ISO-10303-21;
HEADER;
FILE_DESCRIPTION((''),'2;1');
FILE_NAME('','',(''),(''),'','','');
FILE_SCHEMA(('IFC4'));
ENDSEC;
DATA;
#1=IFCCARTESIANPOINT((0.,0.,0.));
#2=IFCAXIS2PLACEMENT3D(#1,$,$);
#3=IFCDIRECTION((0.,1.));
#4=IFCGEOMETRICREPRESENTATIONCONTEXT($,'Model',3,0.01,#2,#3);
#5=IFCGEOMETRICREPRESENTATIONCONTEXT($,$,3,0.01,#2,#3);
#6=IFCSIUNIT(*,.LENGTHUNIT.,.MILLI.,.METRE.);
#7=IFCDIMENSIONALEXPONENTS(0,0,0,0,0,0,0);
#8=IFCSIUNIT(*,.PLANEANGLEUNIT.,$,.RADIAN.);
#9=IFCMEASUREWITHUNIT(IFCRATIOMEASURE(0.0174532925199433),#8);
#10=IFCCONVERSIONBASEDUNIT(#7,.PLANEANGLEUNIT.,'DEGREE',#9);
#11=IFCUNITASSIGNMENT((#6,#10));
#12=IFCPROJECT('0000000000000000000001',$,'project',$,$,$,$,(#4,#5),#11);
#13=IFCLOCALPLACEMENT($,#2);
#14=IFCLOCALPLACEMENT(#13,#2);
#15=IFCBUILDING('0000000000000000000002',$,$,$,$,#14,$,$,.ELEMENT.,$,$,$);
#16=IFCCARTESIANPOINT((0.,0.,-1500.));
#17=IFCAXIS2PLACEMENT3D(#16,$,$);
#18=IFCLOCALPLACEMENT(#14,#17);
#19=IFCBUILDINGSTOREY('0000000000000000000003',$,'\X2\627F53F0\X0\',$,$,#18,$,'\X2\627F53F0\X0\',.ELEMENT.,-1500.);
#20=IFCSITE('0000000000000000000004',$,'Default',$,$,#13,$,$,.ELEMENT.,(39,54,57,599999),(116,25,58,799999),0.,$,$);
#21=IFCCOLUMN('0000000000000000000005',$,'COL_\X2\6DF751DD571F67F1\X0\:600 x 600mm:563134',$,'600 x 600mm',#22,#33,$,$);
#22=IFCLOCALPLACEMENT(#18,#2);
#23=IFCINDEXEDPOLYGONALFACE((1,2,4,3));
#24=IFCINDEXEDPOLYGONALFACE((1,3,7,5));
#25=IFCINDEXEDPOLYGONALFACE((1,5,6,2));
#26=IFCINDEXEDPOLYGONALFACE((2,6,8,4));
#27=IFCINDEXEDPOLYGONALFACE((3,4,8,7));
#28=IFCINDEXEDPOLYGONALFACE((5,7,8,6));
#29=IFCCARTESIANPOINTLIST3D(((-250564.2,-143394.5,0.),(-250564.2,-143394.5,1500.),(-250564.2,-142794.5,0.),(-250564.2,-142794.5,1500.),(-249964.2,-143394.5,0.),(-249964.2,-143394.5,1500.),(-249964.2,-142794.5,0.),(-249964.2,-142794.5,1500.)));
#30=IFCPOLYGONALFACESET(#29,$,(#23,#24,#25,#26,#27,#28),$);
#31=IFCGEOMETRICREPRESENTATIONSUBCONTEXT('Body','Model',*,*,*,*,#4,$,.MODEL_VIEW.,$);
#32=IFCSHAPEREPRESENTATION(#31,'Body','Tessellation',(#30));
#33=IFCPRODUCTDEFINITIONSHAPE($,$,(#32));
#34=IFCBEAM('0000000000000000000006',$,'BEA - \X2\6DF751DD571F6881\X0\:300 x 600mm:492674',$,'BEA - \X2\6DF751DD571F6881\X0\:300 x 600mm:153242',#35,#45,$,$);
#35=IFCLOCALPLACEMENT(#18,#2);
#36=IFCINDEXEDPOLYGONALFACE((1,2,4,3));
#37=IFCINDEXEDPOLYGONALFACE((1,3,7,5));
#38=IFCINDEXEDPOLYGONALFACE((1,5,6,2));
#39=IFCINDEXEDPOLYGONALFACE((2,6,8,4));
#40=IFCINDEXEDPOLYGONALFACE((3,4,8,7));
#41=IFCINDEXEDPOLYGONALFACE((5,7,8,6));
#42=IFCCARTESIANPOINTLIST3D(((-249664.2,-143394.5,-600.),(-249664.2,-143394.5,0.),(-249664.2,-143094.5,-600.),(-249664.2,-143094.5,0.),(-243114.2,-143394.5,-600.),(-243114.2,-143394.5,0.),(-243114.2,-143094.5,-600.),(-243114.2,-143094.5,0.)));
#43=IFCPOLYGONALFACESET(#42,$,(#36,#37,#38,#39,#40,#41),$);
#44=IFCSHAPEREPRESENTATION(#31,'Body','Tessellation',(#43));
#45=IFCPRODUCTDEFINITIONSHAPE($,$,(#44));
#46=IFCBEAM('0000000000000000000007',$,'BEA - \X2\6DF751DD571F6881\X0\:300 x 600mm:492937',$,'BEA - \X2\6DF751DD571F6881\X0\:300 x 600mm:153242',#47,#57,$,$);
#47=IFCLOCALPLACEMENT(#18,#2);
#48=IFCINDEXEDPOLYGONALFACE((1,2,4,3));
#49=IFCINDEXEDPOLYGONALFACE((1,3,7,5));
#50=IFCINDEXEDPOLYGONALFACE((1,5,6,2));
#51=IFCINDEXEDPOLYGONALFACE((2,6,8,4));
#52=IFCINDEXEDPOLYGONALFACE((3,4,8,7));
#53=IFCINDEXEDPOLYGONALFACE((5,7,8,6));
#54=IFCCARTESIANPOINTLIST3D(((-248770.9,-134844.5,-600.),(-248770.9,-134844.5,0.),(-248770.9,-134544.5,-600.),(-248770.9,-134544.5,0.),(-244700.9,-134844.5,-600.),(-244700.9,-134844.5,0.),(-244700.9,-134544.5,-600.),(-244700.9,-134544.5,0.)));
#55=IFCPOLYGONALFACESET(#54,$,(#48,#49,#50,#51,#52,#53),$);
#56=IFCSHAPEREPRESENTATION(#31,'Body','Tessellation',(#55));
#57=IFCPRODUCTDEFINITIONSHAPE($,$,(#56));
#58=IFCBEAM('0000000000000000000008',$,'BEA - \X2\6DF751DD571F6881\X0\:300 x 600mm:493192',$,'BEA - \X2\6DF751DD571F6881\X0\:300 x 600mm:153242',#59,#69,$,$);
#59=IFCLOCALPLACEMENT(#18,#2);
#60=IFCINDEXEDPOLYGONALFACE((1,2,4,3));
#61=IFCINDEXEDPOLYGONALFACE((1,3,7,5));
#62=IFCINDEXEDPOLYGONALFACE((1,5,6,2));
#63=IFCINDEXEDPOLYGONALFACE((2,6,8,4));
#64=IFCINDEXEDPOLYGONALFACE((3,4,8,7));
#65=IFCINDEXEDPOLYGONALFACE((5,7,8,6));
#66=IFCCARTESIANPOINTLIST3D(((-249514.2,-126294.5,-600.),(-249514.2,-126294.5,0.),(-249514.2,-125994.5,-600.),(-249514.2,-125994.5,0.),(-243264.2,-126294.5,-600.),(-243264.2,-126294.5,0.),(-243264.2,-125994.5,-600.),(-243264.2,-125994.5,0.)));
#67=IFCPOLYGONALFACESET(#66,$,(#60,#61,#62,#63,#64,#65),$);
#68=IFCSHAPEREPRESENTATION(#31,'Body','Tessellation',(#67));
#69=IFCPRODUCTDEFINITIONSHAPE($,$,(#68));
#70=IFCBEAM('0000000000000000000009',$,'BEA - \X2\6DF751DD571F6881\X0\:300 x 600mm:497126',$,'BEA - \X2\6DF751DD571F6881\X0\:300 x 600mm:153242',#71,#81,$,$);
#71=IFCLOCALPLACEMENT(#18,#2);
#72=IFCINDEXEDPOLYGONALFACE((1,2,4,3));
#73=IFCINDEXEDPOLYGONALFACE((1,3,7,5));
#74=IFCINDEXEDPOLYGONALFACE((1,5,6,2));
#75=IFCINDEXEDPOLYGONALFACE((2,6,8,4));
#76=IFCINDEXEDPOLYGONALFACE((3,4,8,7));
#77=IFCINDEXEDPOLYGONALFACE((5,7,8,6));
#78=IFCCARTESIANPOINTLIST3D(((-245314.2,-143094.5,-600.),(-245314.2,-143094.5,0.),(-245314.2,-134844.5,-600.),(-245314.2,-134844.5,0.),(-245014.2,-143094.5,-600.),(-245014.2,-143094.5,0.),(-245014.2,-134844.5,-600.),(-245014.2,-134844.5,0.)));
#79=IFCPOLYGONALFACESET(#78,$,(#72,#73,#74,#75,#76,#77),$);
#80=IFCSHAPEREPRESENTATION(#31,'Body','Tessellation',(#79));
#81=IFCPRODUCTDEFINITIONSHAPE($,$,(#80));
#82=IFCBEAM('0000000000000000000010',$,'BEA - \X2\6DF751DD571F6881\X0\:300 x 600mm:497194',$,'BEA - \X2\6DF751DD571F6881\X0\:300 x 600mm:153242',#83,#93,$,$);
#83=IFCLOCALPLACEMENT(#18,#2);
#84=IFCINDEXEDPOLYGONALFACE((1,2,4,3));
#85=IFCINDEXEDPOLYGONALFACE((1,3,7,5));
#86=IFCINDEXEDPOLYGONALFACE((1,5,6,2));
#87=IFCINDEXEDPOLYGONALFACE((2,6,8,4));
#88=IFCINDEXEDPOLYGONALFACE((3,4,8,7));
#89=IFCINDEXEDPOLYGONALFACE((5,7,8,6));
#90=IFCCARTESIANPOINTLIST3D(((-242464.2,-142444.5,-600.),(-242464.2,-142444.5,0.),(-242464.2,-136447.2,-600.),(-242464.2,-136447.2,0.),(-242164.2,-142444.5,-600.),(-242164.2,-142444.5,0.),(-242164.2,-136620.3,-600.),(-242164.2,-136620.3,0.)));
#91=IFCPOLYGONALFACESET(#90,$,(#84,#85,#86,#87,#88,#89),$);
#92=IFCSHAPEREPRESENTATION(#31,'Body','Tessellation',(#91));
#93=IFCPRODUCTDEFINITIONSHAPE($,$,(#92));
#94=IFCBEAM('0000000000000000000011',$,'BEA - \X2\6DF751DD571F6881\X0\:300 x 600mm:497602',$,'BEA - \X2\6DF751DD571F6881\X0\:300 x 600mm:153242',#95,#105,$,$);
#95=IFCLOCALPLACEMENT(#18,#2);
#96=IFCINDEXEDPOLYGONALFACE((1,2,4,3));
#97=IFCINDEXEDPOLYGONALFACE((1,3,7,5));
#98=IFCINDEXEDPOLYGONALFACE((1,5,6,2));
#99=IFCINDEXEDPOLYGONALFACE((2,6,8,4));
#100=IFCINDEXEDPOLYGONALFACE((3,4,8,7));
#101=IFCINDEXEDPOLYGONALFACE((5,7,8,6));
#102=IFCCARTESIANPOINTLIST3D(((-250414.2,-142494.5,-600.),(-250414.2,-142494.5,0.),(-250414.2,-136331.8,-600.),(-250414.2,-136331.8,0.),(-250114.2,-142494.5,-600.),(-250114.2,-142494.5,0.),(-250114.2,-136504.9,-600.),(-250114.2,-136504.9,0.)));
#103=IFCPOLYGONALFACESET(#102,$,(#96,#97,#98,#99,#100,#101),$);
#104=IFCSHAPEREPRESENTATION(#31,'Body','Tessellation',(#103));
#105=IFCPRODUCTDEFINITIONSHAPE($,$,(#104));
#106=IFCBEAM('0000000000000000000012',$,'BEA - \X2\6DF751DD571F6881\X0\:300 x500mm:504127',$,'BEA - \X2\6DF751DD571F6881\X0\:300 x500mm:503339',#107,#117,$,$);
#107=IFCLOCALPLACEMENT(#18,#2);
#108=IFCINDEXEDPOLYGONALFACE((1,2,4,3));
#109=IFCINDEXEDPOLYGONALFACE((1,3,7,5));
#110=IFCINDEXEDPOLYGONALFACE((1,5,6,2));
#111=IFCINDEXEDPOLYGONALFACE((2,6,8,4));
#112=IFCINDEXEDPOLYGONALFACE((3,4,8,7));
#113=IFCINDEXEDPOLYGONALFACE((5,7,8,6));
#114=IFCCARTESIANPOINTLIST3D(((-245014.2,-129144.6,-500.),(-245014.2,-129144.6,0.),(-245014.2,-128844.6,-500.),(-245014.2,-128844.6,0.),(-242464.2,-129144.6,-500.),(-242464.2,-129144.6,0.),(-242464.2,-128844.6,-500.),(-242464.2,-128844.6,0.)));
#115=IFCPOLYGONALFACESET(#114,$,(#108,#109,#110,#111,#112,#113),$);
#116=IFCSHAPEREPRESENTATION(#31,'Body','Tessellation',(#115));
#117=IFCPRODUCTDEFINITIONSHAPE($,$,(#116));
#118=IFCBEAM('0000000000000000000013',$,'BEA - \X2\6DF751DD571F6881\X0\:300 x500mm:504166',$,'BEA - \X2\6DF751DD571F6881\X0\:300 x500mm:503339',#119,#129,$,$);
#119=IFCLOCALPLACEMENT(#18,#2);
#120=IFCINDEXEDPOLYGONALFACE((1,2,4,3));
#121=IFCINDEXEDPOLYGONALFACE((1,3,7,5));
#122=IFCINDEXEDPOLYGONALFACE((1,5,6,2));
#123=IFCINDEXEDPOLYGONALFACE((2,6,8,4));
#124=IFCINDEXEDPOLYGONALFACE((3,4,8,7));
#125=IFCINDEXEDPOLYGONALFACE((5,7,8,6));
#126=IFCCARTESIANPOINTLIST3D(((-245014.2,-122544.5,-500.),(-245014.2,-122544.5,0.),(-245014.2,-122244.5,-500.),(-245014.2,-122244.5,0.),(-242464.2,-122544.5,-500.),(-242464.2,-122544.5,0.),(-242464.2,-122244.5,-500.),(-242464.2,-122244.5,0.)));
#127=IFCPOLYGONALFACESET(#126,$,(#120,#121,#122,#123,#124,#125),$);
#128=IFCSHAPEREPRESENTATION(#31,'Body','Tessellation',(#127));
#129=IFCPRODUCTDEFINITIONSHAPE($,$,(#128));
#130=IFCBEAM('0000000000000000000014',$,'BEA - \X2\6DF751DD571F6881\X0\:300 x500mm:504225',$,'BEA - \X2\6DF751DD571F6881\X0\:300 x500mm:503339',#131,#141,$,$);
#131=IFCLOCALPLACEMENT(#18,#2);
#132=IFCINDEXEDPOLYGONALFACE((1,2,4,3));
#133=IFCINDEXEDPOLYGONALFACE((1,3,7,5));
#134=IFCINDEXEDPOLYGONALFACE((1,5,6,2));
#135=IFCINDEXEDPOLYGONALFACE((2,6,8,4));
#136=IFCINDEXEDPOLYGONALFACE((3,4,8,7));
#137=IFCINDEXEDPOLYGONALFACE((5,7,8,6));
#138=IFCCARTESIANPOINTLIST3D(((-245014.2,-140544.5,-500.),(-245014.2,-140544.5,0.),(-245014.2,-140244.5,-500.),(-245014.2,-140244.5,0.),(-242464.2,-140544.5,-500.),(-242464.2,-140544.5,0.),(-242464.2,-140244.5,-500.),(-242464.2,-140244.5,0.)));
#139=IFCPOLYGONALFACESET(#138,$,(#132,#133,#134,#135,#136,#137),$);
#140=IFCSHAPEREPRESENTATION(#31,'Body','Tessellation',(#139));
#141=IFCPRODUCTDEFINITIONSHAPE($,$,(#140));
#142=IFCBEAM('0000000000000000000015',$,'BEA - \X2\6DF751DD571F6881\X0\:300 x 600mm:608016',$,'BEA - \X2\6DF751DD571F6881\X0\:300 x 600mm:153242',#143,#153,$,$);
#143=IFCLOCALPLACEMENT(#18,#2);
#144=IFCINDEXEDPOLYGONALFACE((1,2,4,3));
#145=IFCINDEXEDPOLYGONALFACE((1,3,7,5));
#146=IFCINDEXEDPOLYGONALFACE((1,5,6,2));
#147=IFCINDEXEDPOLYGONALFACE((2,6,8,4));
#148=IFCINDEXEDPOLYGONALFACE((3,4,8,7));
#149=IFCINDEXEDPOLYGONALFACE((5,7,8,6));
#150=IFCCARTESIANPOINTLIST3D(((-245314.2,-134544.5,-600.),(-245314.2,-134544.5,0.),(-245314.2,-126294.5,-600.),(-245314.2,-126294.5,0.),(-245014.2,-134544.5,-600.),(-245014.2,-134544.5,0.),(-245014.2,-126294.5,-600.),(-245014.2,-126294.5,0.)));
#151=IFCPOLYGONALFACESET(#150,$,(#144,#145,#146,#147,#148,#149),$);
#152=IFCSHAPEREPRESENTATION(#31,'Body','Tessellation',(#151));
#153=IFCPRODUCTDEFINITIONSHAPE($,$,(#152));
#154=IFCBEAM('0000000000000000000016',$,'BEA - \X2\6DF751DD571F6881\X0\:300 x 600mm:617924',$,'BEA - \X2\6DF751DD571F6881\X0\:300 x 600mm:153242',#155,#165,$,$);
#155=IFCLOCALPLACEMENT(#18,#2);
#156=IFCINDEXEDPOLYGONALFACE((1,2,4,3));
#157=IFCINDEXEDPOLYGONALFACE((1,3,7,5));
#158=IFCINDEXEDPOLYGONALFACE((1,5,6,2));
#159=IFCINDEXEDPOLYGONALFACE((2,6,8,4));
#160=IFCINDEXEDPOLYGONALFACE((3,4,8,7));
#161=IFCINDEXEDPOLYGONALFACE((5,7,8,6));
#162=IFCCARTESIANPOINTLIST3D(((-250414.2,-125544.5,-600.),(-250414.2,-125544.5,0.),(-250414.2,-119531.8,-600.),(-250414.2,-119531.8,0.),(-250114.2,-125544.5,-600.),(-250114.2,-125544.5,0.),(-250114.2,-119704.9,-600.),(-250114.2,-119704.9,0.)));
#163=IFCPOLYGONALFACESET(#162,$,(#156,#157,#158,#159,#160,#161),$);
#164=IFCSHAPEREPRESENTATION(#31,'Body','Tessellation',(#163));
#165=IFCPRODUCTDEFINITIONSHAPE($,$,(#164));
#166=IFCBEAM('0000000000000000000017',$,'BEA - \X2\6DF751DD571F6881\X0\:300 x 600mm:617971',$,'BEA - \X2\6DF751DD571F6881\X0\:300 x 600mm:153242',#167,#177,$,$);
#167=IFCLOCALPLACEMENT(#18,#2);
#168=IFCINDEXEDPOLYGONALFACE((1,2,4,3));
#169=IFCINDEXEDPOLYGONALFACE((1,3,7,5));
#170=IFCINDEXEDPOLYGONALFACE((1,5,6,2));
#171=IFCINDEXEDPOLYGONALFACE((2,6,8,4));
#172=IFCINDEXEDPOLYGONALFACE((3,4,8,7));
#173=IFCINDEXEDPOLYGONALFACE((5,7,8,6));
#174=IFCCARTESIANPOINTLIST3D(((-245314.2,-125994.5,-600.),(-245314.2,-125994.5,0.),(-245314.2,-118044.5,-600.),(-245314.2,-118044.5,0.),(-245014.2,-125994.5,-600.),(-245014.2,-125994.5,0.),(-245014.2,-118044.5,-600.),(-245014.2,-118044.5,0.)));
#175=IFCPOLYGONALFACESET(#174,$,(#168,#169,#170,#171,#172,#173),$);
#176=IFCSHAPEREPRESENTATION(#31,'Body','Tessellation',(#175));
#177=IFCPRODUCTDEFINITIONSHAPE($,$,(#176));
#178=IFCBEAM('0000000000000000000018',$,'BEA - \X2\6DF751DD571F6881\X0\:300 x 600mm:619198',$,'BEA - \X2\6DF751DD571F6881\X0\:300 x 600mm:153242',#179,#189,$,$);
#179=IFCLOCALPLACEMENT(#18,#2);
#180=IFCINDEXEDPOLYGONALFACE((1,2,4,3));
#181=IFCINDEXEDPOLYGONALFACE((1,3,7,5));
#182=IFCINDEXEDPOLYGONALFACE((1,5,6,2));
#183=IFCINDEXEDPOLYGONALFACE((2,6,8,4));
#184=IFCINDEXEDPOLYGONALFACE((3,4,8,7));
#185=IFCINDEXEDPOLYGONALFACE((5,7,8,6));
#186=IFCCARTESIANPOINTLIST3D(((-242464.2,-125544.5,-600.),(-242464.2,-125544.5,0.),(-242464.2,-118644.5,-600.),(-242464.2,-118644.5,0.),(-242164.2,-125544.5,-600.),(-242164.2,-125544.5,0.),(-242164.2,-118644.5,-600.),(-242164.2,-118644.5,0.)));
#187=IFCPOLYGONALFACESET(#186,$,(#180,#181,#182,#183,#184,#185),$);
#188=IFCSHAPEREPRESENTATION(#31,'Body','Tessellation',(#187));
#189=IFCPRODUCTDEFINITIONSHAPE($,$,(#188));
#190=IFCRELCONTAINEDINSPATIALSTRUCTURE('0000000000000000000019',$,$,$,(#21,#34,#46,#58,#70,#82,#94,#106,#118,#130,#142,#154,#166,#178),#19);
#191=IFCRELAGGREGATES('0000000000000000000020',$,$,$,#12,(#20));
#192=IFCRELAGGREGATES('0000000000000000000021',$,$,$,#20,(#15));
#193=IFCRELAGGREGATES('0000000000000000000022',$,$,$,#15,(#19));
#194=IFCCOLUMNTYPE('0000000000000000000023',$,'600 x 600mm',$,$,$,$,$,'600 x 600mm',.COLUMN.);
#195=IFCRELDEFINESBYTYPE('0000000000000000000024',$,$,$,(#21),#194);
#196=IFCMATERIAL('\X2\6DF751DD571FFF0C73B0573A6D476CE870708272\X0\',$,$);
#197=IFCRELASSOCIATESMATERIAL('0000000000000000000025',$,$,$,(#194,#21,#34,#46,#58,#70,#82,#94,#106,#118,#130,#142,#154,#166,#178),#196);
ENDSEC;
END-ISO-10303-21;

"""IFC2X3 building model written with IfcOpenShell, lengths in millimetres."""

from ifc_helpers import new_model, entity, si_unit, converted_unit, direction, frame, frame_2d, origin, origin_2d_with_axis, place, context, subcontext, project, spatial, rectangle, extrude, clip, halfspace, source, transform, mapped, material, type_object, type_shapes, element, save


model = new_model("IFC2X3")

# Units and contexts
model_context = context("Model", 3, precision=0.01, world=origin(), true_north=direction((0.0, 1.0)))
context_of_model = context(None, 3, precision=0.01, world=origin(), true_north=direction((0.0, 1.0)))
body_context = subcontext(model_context, "Body", "Model", "MODEL_VIEW")
ifc_project = project(units=[si_unit("LENGTHUNIT", "METRE", prefix="MILLI"), converted_unit("PLANEANGLEUNIT", "DEGREE", entity("IfcRatioMeasure", 0.0174532925199433), si_unit("PLANEANGLEUNIT", "RADIAN"), dimensions=[0, 0, 0, 0, 0, 0, 0])], contexts=[model_context, context_of_model])

# Site, building, storey
site_placement = place(None, origin())
site = spatial("IfcSite", under=ifc_project, at=site_placement, Name="Default", CompositionType="ELEMENT", RefLatitude=(39, 54, 57, 599999), RefLongitude=(116, 25, 58, 799999), RefElevation=0.0)
building_placement = place(site_placement, origin())
building = spatial("IfcBuilding", under=site, at=building_placement, CompositionType="ELEMENT")
storey_placement = place(building_placement, frame((0.0, 0.0, -1500.0)))
storey = spatial("IfcBuildingStorey", under=building, at=storey_placement, Name="承台", LongName="承台", CompositionType="ELEMENT", Elevation=-1500.0)

# Column
ifc_material_1 = material(Name="混凝土，现场浇注灰色")
column_type_1 = type_object("IfcColumnType", Name="600 x 600mm", ElementType="600 x 600mm", PredefinedType="COLUMN", material=ifc_material_1)
shared_shape_1 = source(origin(), body_context, "Body", "SweptSolid", [
    extrude(rectangle(XDim=600.0, YDim=600.0, at=origin_2d_with_axis()), frame((0.0, 0.0, -1500.0), z_axis=(0.0, 0.0, 1.0), x_axis=(-1.0, 0.0, 0.0)), (0.0, 0.0, 1.0), 1500.0),
])
type_shapes(column_type_1, [shared_shape_1])
for number, where, name in (
    (1, (-250264.2, -143094.5, 1500.0), "COL_混凝土柱:600 x 600mm:563134"),
):
    element("IfcColumn", number, at=place(storey_placement, frame(where)), inside=storey, type_object=column_type_1, material=ifc_material_1, Name=name, ObjectType="600 x 600mm", context=body_context, shape_type="MappedRepresentation", body=[
        mapped(shared_shape_1, transform((0.0, 0.0, 0.0), scale=1.0)),
    ])

# Beams
beam_1_placement = place(storey_placement, frame((-243114.2, -143244.5, 0.0), z_axis=(0.0, 0.0, 1.0), x_axis=(-1.0, 0.0, 0.0)))
element("IfcBeam", 2, at=beam_1_placement, inside=storey, material=ifc_material_1, Name="BEA - 混凝土梁:300 x 600mm:492674", ObjectType="BEA - 混凝土梁:300 x 600mm:153242", context=body_context, shape_type="SweptSolid", body=[
    extrude(rectangle(XDim=600.0, YDim=300.0, at=frame_2d((0.0, 0.0), x_axis=(1.0, 0.0))), frame((0.0, 0.0, -300.0), z_axis=(1.0, 0.0, 0.0), x_axis=(0.0, 0.0, -1.0)), (0.0, 0.0, 1.0), 6550.0),
])
beam_2_placement = place(storey_placement, frame((-244700.9, -134694.5, 0.0), z_axis=(0.0, 0.0, 1.0), x_axis=(-1.0, 0.0, 0.0)))
element("IfcBeam", 3, at=beam_2_placement, inside=storey, material=ifc_material_1, Name="BEA - 混凝土梁:300 x 600mm:492937", ObjectType="BEA - 混凝土梁:300 x 600mm:153242", context=body_context, shape_type="SweptSolid", body=[
    extrude(rectangle(XDim=600.0, YDim=300.0, at=frame_2d((0.0, 0.0), x_axis=(1.0, 0.0))), frame((0.0, 0.0, -300.0), z_axis=(1.0, 0.0, 0.0), x_axis=(0.0, 0.0, -1.0)), (0.0, 0.0, 1.0), 4070.0),
])
beam_3_placement = place(storey_placement, frame((-243264.2, -126144.5, 0.0), z_axis=(0.0, 0.0, 1.0), x_axis=(-1.0, 0.0, 0.0)))
element("IfcBeam", 4, at=beam_3_placement, inside=storey, material=ifc_material_1, Name="BEA - 混凝土梁:300 x 600mm:493192", ObjectType="BEA - 混凝土梁:300 x 600mm:153242", context=body_context, shape_type="SweptSolid", body=[
    extrude(rectangle(XDim=600.0, YDim=300.0, at=frame_2d((0.0, 0.0), x_axis=(1.0, 0.0))), frame((0.0, 0.0, -300.0), z_axis=(1.0, 0.0, 0.0), x_axis=(0.0, 0.0, -1.0)), (0.0, 0.0, 1.0), 6250.0),
])
beam_4_placement = place(storey_placement, frame((-245164.2, -143094.5, 0.0), z_axis=(0.0, 0.0, 1.0), x_axis=(0.0, 1.0, 0.0)))
element("IfcBeam", 5, at=beam_4_placement, inside=storey, material=ifc_material_1, Name="BEA - 混凝土梁:300 x 600mm:497126", ObjectType="BEA - 混凝土梁:300 x 600mm:153242", context=body_context, shape_type="SweptSolid", body=[
    extrude(rectangle(XDim=600.0, YDim=300.0, at=origin_2d_with_axis()), frame((0.0, 0.0, -300.0), z_axis=(1.0, 0.0, 0.0), x_axis=(0.0, 0.0, -1.0)), (0.0, 0.0, 1.0), 8250.0),
])
beam_5_placement = place(storey_placement, frame((-242314.2, -142444.5, 0.0), z_axis=(0.0, 0.0, 1.0), x_axis=(0.0, 1.0, 0.0)))
element("IfcBeam", 6, at=beam_5_placement, inside=storey, material=ifc_material_1, Name="BEA - 混凝土梁:300 x 600mm:497194", ObjectType="BEA - 混凝土梁:300 x 600mm:153242", context=body_context, shape_type="Clipping", body=[
    clip(extrude(rectangle(XDim=600.0, YDim=300.0, at=frame_2d((0.0, 0.0), x_axis=(1.0, 0.0))), frame((0.0, 0.0, -300.0), z_axis=(1.0, 0.0, 0.0), x_axis=(0.0, 0.0, -1.0)), (0.0, 0.0, 1.0), 5997.3), halfspace(frame((7288.0, 2386.7, 0.0), z_axis=(0.866125, -0.499827, 0.0), x_axis=(-0.499827, -0.866125, 0.0)), False)),
])
beam_6_placement = place(storey_placement, frame((-250264.2, -142494.5, 0.0), z_axis=(0.0, 0.0, 1.0), x_axis=(0.0, 1.0, 0.0)))
element("IfcBeam", 7, at=beam_6_placement, inside=storey, material=ifc_material_1, Name="BEA - 混凝土梁:300 x 600mm:497602", ObjectType="BEA - 混凝土梁:300 x 600mm:153242", context=body_context, shape_type="Clipping", body=[
    clip(extrude(rectangle(XDim=600.0, YDim=300.0, at=frame_2d((0.0, 0.0), x_axis=(1.0, 0.0))), frame((0.0, 0.0, -300.0), z_axis=(1.0, 0.0, 0.0), x_axis=(0.0, 0.0, -1.0)), (0.0, 0.0, 1.0), 6162.7), halfspace(frame((7338.0, 2186.7, 0.0), z_axis=(0.866125, -0.499827, 0.0), x_axis=(-0.499827, -0.866125, 0.0)), False)),
])
for number, where, name in (
    (8, (-245014.2, -128994.6, 0.0), "BEA - 混凝土梁:300 x500mm:504127"),
    (9, (-245014.2, -122394.5, 0.0), "BEA - 混凝土梁:300 x500mm:504166"),
    (10, (-245014.2, -140394.5, 0.0), "BEA - 混凝土梁:300 x500mm:504225"),
):
    element("IfcBeam", number, at=place(storey_placement, frame(where)), inside=storey, material=ifc_material_1, Name=name, ObjectType="BEA - 混凝土梁:300 x500mm:503339", context=body_context, shape_type="SweptSolid", body=[
        extrude(rectangle(XDim=500.0, YDim=300.0, at=frame_2d((0.0, 0.0), x_axis=(1.0, 0.0))), frame((0.0, 0.0, -250.0), z_axis=(1.0, 0.0, 0.0), x_axis=(0.0, 0.0, -1.0)), (0.0, 0.0, 1.0), 2550.0),
    ])
beam_7_placement = place(storey_placement, frame((-245164.2, -134544.5, 0.0), z_axis=(0.0, 0.0, 1.0), x_axis=(0.0, 1.0, 0.0)))
element("IfcBeam", 11, at=beam_7_placement, inside=storey, material=ifc_material_1, Name="BEA - 混凝土梁:300 x 600mm:608016", ObjectType="BEA - 混凝土梁:300 x 600mm:153242", context=body_context, shape_type="SweptSolid", body=[
    extrude(rectangle(XDim=600.0, YDim=300.0, at=origin_2d_with_axis()), frame((0.0, 0.0, -300.0), z_axis=(1.0, 0.0, 0.0), x_axis=(0.0, 0.0, -1.0)), (0.0, 0.0, 1.0), 8250.0),
])
beam_8_placement = place(storey_placement, frame((-250264.2, -125544.5, 0.0), z_axis=(0.0, 0.0, 1.0), x_axis=(0.0, 1.0, 0.0)))
element("IfcBeam", 12, at=beam_8_placement, inside=storey, material=ifc_material_1, Name="BEA - 混凝土梁:300 x 600mm:617924", ObjectType="BEA - 混凝土梁:300 x 600mm:153242", context=body_context, shape_type="Clipping", body=[
    clip(extrude(rectangle(XDim=600.0, YDim=300.0, at=frame_2d((0.0, 0.0), x_axis=(1.0, 0.0))), frame((0.0, 0.0, -300.0), z_axis=(1.0, 0.0, 0.0), x_axis=(0.0, 0.0, -1.0)), (0.0, 0.0, 1.0), 6012.7), halfspace(frame((7188.0, 2186.7, 0.0), z_axis=(0.866125, -0.499827, 0.0), x_axis=(-0.499827, -0.866125, 0.0)), False)),
])
beam_9_placement = place(storey_placement, frame((-245164.2, -125994.5, 0.0), z_axis=(0.0, 0.0, 1.0), x_axis=(0.0, 1.0, 0.0)))
element("IfcBeam", 13, at=beam_9_placement, inside=storey, material=ifc_material_1, Name="BEA - 混凝土梁:300 x 600mm:617971", ObjectType="BEA - 混凝土梁:300 x 600mm:153242", context=body_context, shape_type="SweptSolid", body=[
    extrude(rectangle(XDim=600.0, YDim=300.0, at=origin_2d_with_axis()), frame((0.0, 0.0, -300.0), z_axis=(1.0, 0.0, 0.0), x_axis=(0.0, 0.0, -1.0)), (0.0, 0.0, 1.0), 7950.0),
])
beam_10_placement = place(storey_placement, frame((-242314.2, -125544.5, 0.0), z_axis=(0.0, 0.0, 1.0), x_axis=(0.0, 1.0, 0.0)))
element("IfcBeam", 14, at=beam_10_placement, inside=storey, material=ifc_material_1, Name="BEA - 混凝土梁:300 x 600mm:619198", ObjectType="BEA - 混凝土梁:300 x 600mm:153242", context=body_context, shape_type="SweptSolid", body=[
    extrude(rectangle(XDim=600.0, YDim=300.0, at=origin_2d_with_axis()), frame((0.0, 0.0, -300.0), z_axis=(1.0, 0.0, 0.0), x_axis=(0.0, 0.0, -1.0)), (0.0, 0.0, 1.0), 6900.0),
])

save(model, "model.ifc")
